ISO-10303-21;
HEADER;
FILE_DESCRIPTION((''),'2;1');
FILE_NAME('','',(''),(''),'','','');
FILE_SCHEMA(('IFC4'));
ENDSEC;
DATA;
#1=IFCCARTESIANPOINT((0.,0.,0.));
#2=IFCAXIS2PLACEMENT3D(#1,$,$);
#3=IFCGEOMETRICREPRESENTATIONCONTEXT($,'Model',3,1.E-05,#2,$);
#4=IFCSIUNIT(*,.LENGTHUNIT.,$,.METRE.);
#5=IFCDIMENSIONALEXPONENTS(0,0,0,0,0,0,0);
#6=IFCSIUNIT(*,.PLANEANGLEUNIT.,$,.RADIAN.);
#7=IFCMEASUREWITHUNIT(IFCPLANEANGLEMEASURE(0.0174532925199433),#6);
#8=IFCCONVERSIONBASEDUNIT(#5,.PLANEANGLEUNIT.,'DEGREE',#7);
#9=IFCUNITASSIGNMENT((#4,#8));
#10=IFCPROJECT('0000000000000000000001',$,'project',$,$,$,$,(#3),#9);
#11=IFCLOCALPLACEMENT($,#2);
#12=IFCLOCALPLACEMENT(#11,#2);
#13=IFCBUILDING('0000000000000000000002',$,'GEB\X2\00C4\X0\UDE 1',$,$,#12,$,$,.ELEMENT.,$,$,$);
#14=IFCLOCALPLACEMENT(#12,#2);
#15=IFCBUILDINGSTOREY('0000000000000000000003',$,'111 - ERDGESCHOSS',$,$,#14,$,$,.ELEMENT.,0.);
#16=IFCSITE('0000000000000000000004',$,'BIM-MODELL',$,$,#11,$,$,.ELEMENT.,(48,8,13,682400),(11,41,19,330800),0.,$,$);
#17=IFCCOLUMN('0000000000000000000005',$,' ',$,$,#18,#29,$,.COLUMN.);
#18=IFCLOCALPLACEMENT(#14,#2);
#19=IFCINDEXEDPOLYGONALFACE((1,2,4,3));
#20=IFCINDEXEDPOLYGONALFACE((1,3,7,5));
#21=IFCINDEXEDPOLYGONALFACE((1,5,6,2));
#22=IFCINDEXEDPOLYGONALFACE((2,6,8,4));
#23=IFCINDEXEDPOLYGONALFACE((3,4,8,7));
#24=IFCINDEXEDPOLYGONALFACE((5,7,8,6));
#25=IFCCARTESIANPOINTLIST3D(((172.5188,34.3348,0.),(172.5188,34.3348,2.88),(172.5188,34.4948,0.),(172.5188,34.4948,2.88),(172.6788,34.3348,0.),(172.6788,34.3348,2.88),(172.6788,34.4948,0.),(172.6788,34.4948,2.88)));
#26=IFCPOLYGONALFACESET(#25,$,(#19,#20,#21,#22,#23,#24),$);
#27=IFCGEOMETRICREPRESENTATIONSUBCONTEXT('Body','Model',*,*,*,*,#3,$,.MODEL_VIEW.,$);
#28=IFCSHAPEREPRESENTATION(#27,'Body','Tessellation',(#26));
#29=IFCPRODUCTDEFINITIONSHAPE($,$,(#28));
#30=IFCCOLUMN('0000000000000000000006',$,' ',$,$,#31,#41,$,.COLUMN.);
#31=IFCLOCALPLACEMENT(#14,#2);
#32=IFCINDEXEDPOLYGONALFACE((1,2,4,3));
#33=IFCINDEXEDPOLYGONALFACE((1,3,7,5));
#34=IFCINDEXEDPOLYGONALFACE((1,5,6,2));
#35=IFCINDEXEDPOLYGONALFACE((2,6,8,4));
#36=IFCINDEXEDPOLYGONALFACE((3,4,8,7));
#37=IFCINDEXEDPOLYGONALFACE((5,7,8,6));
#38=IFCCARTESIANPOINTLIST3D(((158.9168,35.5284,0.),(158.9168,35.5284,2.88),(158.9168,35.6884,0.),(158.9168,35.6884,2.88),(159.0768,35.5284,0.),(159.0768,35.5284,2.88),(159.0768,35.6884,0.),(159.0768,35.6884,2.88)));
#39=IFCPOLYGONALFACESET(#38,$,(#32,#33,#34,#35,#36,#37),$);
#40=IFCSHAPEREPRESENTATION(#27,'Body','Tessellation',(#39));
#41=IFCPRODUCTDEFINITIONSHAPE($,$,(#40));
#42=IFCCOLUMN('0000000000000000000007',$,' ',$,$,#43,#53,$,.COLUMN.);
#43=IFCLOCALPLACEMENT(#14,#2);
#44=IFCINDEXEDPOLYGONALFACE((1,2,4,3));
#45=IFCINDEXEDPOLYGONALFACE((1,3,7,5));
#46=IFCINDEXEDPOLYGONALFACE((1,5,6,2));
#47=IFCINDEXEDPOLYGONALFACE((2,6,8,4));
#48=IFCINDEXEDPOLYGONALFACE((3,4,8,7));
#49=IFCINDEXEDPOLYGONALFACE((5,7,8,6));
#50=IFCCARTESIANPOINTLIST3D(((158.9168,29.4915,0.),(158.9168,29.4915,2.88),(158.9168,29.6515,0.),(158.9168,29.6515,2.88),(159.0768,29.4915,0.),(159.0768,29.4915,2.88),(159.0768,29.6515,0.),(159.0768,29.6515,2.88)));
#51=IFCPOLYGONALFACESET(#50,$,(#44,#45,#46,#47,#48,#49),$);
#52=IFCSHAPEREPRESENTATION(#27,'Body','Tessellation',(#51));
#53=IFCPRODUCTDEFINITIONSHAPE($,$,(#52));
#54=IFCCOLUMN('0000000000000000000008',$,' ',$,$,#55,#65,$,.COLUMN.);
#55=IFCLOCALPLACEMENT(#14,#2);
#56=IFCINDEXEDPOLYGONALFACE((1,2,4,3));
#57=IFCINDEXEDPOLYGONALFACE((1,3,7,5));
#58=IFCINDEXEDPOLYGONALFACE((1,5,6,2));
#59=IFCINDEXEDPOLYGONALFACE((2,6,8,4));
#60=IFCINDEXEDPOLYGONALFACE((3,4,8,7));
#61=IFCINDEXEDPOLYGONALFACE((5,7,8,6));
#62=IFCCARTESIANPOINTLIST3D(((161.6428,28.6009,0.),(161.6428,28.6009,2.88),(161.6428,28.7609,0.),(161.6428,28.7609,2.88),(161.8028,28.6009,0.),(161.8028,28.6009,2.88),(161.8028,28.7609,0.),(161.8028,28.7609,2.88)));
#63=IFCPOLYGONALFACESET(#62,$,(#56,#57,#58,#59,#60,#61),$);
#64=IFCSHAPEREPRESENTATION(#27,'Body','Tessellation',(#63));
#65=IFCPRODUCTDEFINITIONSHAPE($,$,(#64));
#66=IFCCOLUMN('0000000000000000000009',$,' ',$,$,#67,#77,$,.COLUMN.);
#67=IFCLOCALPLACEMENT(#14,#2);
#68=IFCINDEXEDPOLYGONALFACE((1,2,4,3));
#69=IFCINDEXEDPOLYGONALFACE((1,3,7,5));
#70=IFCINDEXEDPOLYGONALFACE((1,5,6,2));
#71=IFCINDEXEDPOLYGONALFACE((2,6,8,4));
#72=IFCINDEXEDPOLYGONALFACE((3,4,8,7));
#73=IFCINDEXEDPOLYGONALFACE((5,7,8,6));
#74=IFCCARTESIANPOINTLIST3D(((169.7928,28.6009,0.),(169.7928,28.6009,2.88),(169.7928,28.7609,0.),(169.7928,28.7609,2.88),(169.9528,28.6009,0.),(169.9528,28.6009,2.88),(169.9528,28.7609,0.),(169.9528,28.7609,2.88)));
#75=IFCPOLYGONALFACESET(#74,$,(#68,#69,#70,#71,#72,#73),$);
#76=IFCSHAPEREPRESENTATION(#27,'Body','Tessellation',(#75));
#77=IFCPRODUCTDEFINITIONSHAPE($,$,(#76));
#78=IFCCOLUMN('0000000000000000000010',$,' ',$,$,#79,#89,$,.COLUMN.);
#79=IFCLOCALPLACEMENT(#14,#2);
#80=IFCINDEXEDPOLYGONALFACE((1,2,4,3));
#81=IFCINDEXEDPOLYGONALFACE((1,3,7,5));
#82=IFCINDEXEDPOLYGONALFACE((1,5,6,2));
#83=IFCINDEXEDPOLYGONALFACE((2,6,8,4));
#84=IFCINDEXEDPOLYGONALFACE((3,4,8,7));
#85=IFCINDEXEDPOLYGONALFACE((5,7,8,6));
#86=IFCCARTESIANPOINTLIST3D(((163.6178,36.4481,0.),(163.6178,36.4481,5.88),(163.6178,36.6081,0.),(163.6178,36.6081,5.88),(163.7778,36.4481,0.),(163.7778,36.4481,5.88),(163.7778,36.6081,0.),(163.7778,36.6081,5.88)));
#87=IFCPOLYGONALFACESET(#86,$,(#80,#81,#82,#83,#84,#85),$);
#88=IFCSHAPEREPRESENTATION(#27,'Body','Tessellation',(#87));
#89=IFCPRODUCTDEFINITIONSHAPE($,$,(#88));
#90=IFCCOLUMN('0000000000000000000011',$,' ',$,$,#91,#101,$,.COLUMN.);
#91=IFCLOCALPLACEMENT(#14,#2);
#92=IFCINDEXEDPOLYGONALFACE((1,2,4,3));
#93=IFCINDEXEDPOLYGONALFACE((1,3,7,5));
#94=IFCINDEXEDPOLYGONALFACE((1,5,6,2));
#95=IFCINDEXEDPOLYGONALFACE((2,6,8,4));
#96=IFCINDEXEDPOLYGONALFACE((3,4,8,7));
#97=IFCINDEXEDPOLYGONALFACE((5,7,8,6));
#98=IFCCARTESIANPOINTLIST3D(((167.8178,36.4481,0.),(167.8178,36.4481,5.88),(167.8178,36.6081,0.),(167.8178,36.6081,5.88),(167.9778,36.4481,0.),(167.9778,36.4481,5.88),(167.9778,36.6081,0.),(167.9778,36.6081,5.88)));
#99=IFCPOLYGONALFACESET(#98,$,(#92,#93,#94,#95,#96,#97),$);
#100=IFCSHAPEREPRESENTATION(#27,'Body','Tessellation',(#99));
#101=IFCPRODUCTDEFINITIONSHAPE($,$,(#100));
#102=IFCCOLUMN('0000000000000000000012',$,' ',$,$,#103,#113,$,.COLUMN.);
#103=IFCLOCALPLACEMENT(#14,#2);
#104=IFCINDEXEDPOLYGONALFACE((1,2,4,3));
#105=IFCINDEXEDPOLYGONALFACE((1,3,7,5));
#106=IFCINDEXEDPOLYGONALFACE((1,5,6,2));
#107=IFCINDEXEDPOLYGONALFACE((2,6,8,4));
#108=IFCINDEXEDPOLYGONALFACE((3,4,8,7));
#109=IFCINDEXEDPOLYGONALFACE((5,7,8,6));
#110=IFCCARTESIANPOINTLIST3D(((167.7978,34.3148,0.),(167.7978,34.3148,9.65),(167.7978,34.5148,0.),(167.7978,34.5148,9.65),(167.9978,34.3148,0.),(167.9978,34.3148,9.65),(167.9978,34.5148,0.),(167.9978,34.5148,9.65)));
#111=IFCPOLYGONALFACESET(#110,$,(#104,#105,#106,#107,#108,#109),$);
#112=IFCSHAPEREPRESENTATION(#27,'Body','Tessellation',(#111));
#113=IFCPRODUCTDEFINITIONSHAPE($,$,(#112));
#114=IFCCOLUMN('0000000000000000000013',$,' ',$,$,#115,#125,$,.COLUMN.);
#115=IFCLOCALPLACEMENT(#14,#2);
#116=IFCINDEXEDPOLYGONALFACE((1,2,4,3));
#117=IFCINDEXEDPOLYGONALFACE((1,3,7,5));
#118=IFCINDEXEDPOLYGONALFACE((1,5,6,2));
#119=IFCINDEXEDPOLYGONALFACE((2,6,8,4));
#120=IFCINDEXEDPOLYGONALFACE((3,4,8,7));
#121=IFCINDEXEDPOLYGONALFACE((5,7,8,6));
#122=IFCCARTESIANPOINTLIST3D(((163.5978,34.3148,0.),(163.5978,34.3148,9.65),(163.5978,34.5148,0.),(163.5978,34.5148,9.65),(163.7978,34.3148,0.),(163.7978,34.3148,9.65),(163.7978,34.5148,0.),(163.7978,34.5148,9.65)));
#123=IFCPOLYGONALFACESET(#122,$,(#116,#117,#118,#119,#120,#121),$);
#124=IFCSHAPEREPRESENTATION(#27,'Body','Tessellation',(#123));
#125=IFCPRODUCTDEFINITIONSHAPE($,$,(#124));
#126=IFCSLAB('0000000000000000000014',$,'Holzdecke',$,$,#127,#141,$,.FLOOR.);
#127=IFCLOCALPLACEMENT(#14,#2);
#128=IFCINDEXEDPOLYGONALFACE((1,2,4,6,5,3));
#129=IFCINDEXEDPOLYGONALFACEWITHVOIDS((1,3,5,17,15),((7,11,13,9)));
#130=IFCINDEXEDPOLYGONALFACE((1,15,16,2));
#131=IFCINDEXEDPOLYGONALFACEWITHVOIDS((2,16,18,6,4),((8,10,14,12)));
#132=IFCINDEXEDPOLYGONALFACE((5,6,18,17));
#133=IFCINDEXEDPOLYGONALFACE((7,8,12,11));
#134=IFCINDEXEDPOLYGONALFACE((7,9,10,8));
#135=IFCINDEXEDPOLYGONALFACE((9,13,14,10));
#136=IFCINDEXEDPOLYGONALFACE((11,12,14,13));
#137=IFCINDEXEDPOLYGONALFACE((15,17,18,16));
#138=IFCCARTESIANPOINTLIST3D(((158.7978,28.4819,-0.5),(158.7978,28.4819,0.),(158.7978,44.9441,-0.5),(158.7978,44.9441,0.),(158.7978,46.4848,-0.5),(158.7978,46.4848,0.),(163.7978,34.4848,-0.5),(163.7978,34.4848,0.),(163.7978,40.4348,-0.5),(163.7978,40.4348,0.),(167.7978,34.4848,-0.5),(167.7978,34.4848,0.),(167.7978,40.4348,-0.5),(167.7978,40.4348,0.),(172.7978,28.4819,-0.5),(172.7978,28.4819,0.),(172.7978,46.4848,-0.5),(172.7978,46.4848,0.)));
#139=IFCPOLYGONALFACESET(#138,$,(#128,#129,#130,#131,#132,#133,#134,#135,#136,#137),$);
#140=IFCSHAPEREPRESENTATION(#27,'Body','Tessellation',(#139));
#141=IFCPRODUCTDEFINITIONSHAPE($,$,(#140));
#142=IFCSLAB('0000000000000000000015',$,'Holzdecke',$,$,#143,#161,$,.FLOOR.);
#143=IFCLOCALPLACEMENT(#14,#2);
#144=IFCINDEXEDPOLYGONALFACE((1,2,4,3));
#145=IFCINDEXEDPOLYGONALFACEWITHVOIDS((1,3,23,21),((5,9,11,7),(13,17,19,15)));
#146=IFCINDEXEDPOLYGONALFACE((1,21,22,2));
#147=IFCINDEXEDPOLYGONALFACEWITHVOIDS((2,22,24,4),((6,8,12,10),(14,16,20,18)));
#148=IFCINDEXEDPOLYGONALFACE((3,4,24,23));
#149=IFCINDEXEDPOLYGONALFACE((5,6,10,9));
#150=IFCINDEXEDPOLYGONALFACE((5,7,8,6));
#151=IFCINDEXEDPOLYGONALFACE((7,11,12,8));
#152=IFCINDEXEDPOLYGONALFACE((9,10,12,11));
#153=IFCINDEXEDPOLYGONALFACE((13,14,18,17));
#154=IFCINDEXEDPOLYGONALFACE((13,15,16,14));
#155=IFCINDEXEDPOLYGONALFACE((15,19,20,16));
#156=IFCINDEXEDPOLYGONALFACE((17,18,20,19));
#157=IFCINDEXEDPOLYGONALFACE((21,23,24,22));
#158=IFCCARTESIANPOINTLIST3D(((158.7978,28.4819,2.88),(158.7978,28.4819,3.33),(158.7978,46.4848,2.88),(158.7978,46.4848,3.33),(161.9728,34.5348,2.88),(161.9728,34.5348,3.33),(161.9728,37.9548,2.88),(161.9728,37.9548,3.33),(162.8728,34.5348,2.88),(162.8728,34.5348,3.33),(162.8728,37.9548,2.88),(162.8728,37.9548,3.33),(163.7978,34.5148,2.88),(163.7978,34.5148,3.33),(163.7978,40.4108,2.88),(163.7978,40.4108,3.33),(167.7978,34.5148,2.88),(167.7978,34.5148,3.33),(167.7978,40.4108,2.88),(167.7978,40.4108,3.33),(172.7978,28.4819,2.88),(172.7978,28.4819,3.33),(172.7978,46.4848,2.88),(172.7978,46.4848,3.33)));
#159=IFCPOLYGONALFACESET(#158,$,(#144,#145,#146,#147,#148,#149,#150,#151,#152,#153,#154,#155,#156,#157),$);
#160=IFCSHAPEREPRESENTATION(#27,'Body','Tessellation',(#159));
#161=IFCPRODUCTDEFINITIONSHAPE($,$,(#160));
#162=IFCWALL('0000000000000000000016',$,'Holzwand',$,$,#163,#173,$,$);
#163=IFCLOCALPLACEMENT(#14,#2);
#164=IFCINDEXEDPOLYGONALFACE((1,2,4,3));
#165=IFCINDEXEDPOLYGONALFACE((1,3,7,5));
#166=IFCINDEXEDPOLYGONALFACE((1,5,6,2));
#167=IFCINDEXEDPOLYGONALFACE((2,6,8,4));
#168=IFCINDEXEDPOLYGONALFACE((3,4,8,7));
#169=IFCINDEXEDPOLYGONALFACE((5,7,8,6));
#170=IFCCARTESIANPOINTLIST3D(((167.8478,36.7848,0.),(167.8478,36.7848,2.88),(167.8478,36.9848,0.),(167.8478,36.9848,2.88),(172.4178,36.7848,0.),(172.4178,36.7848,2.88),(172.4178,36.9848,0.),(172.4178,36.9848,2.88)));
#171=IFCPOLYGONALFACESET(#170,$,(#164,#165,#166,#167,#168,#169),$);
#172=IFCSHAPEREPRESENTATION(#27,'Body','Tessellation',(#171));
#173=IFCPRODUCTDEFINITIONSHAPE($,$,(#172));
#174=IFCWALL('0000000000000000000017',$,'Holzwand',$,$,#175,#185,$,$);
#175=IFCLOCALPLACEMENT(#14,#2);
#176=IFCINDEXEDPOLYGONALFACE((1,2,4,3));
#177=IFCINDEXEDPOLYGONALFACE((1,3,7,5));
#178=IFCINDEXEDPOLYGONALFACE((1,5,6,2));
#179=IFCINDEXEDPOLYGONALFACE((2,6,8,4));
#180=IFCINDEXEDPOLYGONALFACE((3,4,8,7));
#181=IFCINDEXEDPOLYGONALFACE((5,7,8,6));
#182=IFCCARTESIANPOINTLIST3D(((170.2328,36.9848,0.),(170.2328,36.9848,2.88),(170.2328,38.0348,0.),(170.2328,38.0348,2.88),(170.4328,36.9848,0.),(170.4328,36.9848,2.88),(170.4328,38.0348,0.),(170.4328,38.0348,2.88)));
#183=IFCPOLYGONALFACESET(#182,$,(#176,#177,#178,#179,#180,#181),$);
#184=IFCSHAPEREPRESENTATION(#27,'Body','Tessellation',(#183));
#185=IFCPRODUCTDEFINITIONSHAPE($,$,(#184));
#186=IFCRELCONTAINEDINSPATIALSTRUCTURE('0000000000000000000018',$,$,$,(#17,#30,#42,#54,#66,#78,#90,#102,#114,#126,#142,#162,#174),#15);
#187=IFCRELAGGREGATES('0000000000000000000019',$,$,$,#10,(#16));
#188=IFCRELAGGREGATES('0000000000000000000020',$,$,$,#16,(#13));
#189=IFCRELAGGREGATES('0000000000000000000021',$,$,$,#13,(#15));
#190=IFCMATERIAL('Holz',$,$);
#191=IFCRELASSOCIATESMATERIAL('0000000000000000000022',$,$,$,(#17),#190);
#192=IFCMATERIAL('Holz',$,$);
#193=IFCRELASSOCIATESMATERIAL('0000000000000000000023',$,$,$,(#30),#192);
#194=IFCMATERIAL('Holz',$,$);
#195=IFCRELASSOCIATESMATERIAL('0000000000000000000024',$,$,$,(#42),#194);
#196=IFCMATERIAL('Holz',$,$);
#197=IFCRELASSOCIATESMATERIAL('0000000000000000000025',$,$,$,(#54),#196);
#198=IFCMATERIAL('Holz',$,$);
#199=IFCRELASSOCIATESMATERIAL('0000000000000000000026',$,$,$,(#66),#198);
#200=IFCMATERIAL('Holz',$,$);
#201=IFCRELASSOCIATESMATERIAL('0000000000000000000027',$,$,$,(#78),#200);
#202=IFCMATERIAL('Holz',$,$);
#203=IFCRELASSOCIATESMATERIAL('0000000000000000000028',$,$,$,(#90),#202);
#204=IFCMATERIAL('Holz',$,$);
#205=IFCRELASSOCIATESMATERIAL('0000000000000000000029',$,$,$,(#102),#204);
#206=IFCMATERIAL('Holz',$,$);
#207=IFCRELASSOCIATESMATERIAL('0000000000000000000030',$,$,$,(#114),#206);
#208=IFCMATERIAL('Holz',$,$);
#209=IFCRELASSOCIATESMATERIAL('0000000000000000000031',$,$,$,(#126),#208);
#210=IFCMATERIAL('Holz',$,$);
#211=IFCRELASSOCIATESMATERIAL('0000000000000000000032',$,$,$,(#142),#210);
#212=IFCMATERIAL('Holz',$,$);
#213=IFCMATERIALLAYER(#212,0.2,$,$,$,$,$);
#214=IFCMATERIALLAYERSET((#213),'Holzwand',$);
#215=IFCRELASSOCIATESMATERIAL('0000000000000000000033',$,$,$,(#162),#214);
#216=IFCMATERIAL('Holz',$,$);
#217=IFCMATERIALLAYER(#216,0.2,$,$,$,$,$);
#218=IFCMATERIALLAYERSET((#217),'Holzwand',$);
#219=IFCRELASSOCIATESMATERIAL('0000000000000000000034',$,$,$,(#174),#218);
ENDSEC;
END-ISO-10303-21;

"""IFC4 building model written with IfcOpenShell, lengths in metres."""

from ifc_helpers import new_model, entity, si_unit, converted_unit, frame, frame_2d, origin, origin_with_axes, place, context, subcontext, project, spatial, polyline, rectangle, outline, extrude, material, layer, layer_set, layer_usage, element, save


model = new_model("IFC4")

# Units and contexts
model_context = context("Model", 3, precision=1e-05, world=origin())
body_context = subcontext(model_context, "Body", "Model", "MODEL_VIEW")
ifc_project = project(units=[si_unit("LENGTHUNIT", "METRE"), converted_unit("PLANEANGLEUNIT", "DEGREE", entity("IfcPlaneAngleMeasure", 0.0174532925199433), si_unit("PLANEANGLEUNIT", "RADIAN"), dimensions=[0, 0, 0, 0, 0, 0, 0])], contexts=[model_context])

# Site, building, storey
site_placement = place(None, origin())
site = spatial("IfcSite", under=ifc_project, at=site_placement, Name="BIM-MODELL", CompositionType="ELEMENT", RefLatitude=(48, 8, 13, 682400), RefLongitude=(11, 41, 19, 330800), RefElevation=0.0)
building_placement = place(site_placement, origin())
building = spatial("IfcBuilding", under=site, at=building_placement, Name="GEBÄUDE 1", CompositionType="ELEMENT")
storey_placement = place(building_placement, origin())
storey = spatial("IfcBuildingStorey", under=building, at=storey_placement, Name="111 - ERDGESCHOSS", CompositionType="ELEMENT", Elevation=0.0)

# Columns
ifc_material_1 = material(Name="Holz")
column_1_placement = place(storey_placement, frame((172.5188, 34.3348, 0.0)))
element("IfcColumn", 1, at=column_1_placement, inside=storey, material=ifc_material_1, Name=" ", PredefinedType="COLUMN", context=body_context, shape_type="SweptSolid", body=[
    extrude(rectangle(XDim=0.16, YDim=0.16, at=frame_2d((0.08, 0.08), x_axis=(1.0, 0.0))), origin_with_axes(), (0.0, 0.0, 1.0), 2.88),
])
ifc_material_2 = material(Name="Holz")
column_2_placement = place(storey_placement, frame((158.9168, 35.5284, 0.0)))
element("IfcColumn", 2, at=column_2_placement, inside=storey, material=ifc_material_2, Name=" ", PredefinedType="COLUMN", context=body_context, shape_type="SweptSolid", body=[
    extrude(rectangle(XDim=0.16, YDim=0.16, at=frame_2d((0.08, 0.08), x_axis=(1.0, 0.0))), origin_with_axes(), (0.0, 0.0, 1.0), 2.88),
])
ifc_material_3 = material(Name="Holz")
column_3_placement = place(storey_placement, frame((158.9168, 29.4915, 0.0)))
element("IfcColumn", 3, at=column_3_placement, inside=storey, material=ifc_material_3, Name=" ", PredefinedType="COLUMN", context=body_context, shape_type="SweptSolid", body=[
    extrude(rectangle(XDim=0.16, YDim=0.16, at=frame_2d((0.08, 0.08), x_axis=(1.0, 0.0))), origin_with_axes(), (0.0, 0.0, 1.0), 2.88),
])
ifc_material_4 = material(Name="Holz")
column_4_placement = place(storey_placement, frame((161.6428, 28.6009, 0.0)))
element("IfcColumn", 4, at=column_4_placement, inside=storey, material=ifc_material_4, Name=" ", PredefinedType="COLUMN", context=body_context, shape_type="SweptSolid", body=[
    extrude(rectangle(XDim=0.16, YDim=0.16, at=frame_2d((0.08, 0.08), x_axis=(1.0, 0.0))), origin_with_axes(), (0.0, 0.0, 1.0), 2.88),
])
ifc_material_5 = material(Name="Holz")
column_5_placement = place(storey_placement, frame((169.7928, 28.6009, 0.0)))
element("IfcColumn", 5, at=column_5_placement, inside=storey, material=ifc_material_5, Name=" ", PredefinedType="COLUMN", context=body_context, shape_type="SweptSolid", body=[
    extrude(rectangle(XDim=0.16, YDim=0.16, at=frame_2d((0.08, 0.08), x_axis=(1.0, 0.0))), origin_with_axes(), (0.0, 0.0, 1.0), 2.88),
])
ifc_material_6 = material(Name="Holz")
column_6_placement = place(storey_placement, frame((163.6178, 36.4481, 0.0)))
element("IfcColumn", 6, at=column_6_placement, inside=storey, material=ifc_material_6, Name=" ", PredefinedType="COLUMN", context=body_context, shape_type="SweptSolid", body=[
    extrude(rectangle(XDim=0.16, YDim=0.16, at=frame_2d((0.08, 0.08), x_axis=(1.0, 0.0))), origin_with_axes(), (0.0, 0.0, 1.0), 5.88),
])
ifc_material_7 = material(Name="Holz")
column_7_placement = place(storey_placement, frame((167.8178, 36.4481, 0.0)))
element("IfcColumn", 7, at=column_7_placement, inside=storey, material=ifc_material_7, Name=" ", PredefinedType="COLUMN", context=body_context, shape_type="SweptSolid", body=[
    extrude(rectangle(XDim=0.16, YDim=0.16, at=frame_2d((0.08, 0.08), x_axis=(1.0, 0.0))), origin_with_axes(), (0.0, 0.0, 1.0), 5.88),
])
ifc_material_8 = material(Name="Holz")
column_8_placement = place(storey_placement, frame((167.7978, 34.3148, 0.0)))
element("IfcColumn", 8, at=column_8_placement, inside=storey, material=ifc_material_8, Name=" ", PredefinedType="COLUMN", context=body_context, shape_type="SweptSolid", body=[
    extrude(rectangle(XDim=0.2, YDim=0.2, at=frame_2d((0.1, 0.1), x_axis=(1.0, 0.0))), origin_with_axes(), (0.0, 0.0, 1.0), 9.65),
])
ifc_material_9 = material(Name="Holz")
column_9_placement = place(storey_placement, frame((163.5978, 34.3148, 0.0)))
element("IfcColumn", 9, at=column_9_placement, inside=storey, material=ifc_material_9, Name=" ", PredefinedType="COLUMN", context=body_context, shape_type="SweptSolid", body=[
    extrude(rectangle(XDim=0.2, YDim=0.2, at=frame_2d((0.1, 0.1), x_axis=(1.0, 0.0))), origin_with_axes(), (0.0, 0.0, 1.0), 9.65),
])

# Slab
ifc_material_10 = material(Name="Holz")
slab_1_placement = place(storey_placement, frame((158.7978, 28.4819, -0.5)))
element("IfcSlab", 10, at=slab_1_placement, inside=storey, material=ifc_material_10, Name="Holzdecke", PredefinedType="FLOOR", context=body_context, shape_type="SweptSolid", body=[
    extrude(outline(polyline([(0.0, 16.4622), (0.0, 0.0), (14.0, 0.0), (14.0, 18.0029), (0.0, 18.0029), (0.0, 16.4622)]), holes=[polyline([(5.0, 11.9529), (9.0, 11.9529), (9.0, 6.0029), (5.0, 6.0029), (5.0, 11.9529)])]), origin_with_axes(), (0.0, 0.0, 1.0), 0.5),
])

# Slab, openings
ifc_material_11 = material(Name="Holz")
slab_2_placement = place(storey_placement, frame((158.7978, 28.4819, 2.88)))
slab_2 = element("IfcSlab", 11, at=slab_2_placement, inside=storey, material=ifc_material_11, Name="Holzdecke", PredefinedType="FLOOR", context=body_context, shape_type="SweptSolid", body=[
    extrude(rectangle(XDim=18.0029, YDim=14.0, at=frame_2d((-7.0, 9.0014), x_axis=(0.0, 1.0))), frame((14.0, 0.0, 0.0), z_axis=(0.0, 0.0, 1.0), x_axis=(1.0, 0.0, 0.0)), (0.0, 0.0, 1.0), 0.45),
])
opening_1_placement = place(slab_2_placement, frame((3.175, 6.0529, 0.0)))
element("IfcOpeningElement", 12, at=opening_1_placement, cuts=slab_2, ObjectType="Opening", context=body_context, shape_type="SweptSolid", body=[
    extrude(rectangle(XDim=0.9, YDim=3.42, at=frame_2d((0.0, 0.0), x_axis=(-1.0, 0.0))), frame((0.45, 1.71, 0.0), z_axis=(0.0, 0.0, 1.0), x_axis=(1.0, 0.0, 0.0)), (0.0, 0.0, 1.0), 0.45),
])
opening_2_placement = place(slab_2_placement, frame((5.0, 6.0329, 0.0)))
element("IfcOpeningElement", 13, at=opening_2_placement, cuts=slab_2, ObjectType="Opening", context=body_context, shape_type="SweptSolid", body=[
    extrude(rectangle(XDim=4.0, YDim=5.896, at=frame_2d((0.0, 0.0), x_axis=(-1.0, 0.0))), frame((2.0, 2.948, 0.0), z_axis=(0.0, 0.0, 1.0), x_axis=(1.0, 0.0, 0.0)), (0.0, 0.0, 1.0), 0.45),
])

# Walls
ifc_material_12 = material(Name="Holz")
ifc_layer_1 = layer(ifc_material_12, 0.2)
ifc_layer_set_1 = layer_set([ifc_layer_1], Name="Holzwand")
ifc_layer_usage_1 = layer_usage(ifc_layer_set_1, "AXIS2", "POSITIVE", 0.0)
wall_1_placement = place(storey_placement, frame((172.4178, 36.9848, 0.0), z_axis=(0.0, 0.0, 1.0), x_axis=(-1.0, 0.0, 0.0)))
element("IfcWall", 14, at=wall_1_placement, inside=storey, material=ifc_layer_usage_1, Name="Holzwand", context=body_context, shape_type="SweptSolid", body=[
    extrude(rectangle(XDim=4.57, YDim=0.2, at=frame_2d((2.285, 0.1), x_axis=(1.0, 0.0))), origin_with_axes(), (0.0, 0.0, 1.0), 2.88),
])
ifc_material_13 = material(Name="Holz")
ifc_layer_2 = layer(ifc_material_13, 0.2)
ifc_layer_set_2 = layer_set([ifc_layer_2], Name="Holzwand")
ifc_layer_usage_2 = layer_usage(ifc_layer_set_2, "AXIS2", "POSITIVE", -0.075)
wall_2_placement = place(storey_placement, frame((170.4328, 36.9848, 0.0), z_axis=(0.0, 0.0, 1.0), x_axis=(0.0, 1.0, 0.0)))
element("IfcWall", 15, at=wall_2_placement, inside=storey, material=ifc_layer_usage_2, Name="Holzwand", context=body_context, shape_type="SweptSolid", body=[
    extrude(rectangle(XDim=1.05, YDim=0.2, at=frame_2d((0.525, 0.1), x_axis=(1.0, 0.0))), origin_with_axes(), (0.0, 0.0, 1.0), 2.88),
])

save(model, "model.ifc")
